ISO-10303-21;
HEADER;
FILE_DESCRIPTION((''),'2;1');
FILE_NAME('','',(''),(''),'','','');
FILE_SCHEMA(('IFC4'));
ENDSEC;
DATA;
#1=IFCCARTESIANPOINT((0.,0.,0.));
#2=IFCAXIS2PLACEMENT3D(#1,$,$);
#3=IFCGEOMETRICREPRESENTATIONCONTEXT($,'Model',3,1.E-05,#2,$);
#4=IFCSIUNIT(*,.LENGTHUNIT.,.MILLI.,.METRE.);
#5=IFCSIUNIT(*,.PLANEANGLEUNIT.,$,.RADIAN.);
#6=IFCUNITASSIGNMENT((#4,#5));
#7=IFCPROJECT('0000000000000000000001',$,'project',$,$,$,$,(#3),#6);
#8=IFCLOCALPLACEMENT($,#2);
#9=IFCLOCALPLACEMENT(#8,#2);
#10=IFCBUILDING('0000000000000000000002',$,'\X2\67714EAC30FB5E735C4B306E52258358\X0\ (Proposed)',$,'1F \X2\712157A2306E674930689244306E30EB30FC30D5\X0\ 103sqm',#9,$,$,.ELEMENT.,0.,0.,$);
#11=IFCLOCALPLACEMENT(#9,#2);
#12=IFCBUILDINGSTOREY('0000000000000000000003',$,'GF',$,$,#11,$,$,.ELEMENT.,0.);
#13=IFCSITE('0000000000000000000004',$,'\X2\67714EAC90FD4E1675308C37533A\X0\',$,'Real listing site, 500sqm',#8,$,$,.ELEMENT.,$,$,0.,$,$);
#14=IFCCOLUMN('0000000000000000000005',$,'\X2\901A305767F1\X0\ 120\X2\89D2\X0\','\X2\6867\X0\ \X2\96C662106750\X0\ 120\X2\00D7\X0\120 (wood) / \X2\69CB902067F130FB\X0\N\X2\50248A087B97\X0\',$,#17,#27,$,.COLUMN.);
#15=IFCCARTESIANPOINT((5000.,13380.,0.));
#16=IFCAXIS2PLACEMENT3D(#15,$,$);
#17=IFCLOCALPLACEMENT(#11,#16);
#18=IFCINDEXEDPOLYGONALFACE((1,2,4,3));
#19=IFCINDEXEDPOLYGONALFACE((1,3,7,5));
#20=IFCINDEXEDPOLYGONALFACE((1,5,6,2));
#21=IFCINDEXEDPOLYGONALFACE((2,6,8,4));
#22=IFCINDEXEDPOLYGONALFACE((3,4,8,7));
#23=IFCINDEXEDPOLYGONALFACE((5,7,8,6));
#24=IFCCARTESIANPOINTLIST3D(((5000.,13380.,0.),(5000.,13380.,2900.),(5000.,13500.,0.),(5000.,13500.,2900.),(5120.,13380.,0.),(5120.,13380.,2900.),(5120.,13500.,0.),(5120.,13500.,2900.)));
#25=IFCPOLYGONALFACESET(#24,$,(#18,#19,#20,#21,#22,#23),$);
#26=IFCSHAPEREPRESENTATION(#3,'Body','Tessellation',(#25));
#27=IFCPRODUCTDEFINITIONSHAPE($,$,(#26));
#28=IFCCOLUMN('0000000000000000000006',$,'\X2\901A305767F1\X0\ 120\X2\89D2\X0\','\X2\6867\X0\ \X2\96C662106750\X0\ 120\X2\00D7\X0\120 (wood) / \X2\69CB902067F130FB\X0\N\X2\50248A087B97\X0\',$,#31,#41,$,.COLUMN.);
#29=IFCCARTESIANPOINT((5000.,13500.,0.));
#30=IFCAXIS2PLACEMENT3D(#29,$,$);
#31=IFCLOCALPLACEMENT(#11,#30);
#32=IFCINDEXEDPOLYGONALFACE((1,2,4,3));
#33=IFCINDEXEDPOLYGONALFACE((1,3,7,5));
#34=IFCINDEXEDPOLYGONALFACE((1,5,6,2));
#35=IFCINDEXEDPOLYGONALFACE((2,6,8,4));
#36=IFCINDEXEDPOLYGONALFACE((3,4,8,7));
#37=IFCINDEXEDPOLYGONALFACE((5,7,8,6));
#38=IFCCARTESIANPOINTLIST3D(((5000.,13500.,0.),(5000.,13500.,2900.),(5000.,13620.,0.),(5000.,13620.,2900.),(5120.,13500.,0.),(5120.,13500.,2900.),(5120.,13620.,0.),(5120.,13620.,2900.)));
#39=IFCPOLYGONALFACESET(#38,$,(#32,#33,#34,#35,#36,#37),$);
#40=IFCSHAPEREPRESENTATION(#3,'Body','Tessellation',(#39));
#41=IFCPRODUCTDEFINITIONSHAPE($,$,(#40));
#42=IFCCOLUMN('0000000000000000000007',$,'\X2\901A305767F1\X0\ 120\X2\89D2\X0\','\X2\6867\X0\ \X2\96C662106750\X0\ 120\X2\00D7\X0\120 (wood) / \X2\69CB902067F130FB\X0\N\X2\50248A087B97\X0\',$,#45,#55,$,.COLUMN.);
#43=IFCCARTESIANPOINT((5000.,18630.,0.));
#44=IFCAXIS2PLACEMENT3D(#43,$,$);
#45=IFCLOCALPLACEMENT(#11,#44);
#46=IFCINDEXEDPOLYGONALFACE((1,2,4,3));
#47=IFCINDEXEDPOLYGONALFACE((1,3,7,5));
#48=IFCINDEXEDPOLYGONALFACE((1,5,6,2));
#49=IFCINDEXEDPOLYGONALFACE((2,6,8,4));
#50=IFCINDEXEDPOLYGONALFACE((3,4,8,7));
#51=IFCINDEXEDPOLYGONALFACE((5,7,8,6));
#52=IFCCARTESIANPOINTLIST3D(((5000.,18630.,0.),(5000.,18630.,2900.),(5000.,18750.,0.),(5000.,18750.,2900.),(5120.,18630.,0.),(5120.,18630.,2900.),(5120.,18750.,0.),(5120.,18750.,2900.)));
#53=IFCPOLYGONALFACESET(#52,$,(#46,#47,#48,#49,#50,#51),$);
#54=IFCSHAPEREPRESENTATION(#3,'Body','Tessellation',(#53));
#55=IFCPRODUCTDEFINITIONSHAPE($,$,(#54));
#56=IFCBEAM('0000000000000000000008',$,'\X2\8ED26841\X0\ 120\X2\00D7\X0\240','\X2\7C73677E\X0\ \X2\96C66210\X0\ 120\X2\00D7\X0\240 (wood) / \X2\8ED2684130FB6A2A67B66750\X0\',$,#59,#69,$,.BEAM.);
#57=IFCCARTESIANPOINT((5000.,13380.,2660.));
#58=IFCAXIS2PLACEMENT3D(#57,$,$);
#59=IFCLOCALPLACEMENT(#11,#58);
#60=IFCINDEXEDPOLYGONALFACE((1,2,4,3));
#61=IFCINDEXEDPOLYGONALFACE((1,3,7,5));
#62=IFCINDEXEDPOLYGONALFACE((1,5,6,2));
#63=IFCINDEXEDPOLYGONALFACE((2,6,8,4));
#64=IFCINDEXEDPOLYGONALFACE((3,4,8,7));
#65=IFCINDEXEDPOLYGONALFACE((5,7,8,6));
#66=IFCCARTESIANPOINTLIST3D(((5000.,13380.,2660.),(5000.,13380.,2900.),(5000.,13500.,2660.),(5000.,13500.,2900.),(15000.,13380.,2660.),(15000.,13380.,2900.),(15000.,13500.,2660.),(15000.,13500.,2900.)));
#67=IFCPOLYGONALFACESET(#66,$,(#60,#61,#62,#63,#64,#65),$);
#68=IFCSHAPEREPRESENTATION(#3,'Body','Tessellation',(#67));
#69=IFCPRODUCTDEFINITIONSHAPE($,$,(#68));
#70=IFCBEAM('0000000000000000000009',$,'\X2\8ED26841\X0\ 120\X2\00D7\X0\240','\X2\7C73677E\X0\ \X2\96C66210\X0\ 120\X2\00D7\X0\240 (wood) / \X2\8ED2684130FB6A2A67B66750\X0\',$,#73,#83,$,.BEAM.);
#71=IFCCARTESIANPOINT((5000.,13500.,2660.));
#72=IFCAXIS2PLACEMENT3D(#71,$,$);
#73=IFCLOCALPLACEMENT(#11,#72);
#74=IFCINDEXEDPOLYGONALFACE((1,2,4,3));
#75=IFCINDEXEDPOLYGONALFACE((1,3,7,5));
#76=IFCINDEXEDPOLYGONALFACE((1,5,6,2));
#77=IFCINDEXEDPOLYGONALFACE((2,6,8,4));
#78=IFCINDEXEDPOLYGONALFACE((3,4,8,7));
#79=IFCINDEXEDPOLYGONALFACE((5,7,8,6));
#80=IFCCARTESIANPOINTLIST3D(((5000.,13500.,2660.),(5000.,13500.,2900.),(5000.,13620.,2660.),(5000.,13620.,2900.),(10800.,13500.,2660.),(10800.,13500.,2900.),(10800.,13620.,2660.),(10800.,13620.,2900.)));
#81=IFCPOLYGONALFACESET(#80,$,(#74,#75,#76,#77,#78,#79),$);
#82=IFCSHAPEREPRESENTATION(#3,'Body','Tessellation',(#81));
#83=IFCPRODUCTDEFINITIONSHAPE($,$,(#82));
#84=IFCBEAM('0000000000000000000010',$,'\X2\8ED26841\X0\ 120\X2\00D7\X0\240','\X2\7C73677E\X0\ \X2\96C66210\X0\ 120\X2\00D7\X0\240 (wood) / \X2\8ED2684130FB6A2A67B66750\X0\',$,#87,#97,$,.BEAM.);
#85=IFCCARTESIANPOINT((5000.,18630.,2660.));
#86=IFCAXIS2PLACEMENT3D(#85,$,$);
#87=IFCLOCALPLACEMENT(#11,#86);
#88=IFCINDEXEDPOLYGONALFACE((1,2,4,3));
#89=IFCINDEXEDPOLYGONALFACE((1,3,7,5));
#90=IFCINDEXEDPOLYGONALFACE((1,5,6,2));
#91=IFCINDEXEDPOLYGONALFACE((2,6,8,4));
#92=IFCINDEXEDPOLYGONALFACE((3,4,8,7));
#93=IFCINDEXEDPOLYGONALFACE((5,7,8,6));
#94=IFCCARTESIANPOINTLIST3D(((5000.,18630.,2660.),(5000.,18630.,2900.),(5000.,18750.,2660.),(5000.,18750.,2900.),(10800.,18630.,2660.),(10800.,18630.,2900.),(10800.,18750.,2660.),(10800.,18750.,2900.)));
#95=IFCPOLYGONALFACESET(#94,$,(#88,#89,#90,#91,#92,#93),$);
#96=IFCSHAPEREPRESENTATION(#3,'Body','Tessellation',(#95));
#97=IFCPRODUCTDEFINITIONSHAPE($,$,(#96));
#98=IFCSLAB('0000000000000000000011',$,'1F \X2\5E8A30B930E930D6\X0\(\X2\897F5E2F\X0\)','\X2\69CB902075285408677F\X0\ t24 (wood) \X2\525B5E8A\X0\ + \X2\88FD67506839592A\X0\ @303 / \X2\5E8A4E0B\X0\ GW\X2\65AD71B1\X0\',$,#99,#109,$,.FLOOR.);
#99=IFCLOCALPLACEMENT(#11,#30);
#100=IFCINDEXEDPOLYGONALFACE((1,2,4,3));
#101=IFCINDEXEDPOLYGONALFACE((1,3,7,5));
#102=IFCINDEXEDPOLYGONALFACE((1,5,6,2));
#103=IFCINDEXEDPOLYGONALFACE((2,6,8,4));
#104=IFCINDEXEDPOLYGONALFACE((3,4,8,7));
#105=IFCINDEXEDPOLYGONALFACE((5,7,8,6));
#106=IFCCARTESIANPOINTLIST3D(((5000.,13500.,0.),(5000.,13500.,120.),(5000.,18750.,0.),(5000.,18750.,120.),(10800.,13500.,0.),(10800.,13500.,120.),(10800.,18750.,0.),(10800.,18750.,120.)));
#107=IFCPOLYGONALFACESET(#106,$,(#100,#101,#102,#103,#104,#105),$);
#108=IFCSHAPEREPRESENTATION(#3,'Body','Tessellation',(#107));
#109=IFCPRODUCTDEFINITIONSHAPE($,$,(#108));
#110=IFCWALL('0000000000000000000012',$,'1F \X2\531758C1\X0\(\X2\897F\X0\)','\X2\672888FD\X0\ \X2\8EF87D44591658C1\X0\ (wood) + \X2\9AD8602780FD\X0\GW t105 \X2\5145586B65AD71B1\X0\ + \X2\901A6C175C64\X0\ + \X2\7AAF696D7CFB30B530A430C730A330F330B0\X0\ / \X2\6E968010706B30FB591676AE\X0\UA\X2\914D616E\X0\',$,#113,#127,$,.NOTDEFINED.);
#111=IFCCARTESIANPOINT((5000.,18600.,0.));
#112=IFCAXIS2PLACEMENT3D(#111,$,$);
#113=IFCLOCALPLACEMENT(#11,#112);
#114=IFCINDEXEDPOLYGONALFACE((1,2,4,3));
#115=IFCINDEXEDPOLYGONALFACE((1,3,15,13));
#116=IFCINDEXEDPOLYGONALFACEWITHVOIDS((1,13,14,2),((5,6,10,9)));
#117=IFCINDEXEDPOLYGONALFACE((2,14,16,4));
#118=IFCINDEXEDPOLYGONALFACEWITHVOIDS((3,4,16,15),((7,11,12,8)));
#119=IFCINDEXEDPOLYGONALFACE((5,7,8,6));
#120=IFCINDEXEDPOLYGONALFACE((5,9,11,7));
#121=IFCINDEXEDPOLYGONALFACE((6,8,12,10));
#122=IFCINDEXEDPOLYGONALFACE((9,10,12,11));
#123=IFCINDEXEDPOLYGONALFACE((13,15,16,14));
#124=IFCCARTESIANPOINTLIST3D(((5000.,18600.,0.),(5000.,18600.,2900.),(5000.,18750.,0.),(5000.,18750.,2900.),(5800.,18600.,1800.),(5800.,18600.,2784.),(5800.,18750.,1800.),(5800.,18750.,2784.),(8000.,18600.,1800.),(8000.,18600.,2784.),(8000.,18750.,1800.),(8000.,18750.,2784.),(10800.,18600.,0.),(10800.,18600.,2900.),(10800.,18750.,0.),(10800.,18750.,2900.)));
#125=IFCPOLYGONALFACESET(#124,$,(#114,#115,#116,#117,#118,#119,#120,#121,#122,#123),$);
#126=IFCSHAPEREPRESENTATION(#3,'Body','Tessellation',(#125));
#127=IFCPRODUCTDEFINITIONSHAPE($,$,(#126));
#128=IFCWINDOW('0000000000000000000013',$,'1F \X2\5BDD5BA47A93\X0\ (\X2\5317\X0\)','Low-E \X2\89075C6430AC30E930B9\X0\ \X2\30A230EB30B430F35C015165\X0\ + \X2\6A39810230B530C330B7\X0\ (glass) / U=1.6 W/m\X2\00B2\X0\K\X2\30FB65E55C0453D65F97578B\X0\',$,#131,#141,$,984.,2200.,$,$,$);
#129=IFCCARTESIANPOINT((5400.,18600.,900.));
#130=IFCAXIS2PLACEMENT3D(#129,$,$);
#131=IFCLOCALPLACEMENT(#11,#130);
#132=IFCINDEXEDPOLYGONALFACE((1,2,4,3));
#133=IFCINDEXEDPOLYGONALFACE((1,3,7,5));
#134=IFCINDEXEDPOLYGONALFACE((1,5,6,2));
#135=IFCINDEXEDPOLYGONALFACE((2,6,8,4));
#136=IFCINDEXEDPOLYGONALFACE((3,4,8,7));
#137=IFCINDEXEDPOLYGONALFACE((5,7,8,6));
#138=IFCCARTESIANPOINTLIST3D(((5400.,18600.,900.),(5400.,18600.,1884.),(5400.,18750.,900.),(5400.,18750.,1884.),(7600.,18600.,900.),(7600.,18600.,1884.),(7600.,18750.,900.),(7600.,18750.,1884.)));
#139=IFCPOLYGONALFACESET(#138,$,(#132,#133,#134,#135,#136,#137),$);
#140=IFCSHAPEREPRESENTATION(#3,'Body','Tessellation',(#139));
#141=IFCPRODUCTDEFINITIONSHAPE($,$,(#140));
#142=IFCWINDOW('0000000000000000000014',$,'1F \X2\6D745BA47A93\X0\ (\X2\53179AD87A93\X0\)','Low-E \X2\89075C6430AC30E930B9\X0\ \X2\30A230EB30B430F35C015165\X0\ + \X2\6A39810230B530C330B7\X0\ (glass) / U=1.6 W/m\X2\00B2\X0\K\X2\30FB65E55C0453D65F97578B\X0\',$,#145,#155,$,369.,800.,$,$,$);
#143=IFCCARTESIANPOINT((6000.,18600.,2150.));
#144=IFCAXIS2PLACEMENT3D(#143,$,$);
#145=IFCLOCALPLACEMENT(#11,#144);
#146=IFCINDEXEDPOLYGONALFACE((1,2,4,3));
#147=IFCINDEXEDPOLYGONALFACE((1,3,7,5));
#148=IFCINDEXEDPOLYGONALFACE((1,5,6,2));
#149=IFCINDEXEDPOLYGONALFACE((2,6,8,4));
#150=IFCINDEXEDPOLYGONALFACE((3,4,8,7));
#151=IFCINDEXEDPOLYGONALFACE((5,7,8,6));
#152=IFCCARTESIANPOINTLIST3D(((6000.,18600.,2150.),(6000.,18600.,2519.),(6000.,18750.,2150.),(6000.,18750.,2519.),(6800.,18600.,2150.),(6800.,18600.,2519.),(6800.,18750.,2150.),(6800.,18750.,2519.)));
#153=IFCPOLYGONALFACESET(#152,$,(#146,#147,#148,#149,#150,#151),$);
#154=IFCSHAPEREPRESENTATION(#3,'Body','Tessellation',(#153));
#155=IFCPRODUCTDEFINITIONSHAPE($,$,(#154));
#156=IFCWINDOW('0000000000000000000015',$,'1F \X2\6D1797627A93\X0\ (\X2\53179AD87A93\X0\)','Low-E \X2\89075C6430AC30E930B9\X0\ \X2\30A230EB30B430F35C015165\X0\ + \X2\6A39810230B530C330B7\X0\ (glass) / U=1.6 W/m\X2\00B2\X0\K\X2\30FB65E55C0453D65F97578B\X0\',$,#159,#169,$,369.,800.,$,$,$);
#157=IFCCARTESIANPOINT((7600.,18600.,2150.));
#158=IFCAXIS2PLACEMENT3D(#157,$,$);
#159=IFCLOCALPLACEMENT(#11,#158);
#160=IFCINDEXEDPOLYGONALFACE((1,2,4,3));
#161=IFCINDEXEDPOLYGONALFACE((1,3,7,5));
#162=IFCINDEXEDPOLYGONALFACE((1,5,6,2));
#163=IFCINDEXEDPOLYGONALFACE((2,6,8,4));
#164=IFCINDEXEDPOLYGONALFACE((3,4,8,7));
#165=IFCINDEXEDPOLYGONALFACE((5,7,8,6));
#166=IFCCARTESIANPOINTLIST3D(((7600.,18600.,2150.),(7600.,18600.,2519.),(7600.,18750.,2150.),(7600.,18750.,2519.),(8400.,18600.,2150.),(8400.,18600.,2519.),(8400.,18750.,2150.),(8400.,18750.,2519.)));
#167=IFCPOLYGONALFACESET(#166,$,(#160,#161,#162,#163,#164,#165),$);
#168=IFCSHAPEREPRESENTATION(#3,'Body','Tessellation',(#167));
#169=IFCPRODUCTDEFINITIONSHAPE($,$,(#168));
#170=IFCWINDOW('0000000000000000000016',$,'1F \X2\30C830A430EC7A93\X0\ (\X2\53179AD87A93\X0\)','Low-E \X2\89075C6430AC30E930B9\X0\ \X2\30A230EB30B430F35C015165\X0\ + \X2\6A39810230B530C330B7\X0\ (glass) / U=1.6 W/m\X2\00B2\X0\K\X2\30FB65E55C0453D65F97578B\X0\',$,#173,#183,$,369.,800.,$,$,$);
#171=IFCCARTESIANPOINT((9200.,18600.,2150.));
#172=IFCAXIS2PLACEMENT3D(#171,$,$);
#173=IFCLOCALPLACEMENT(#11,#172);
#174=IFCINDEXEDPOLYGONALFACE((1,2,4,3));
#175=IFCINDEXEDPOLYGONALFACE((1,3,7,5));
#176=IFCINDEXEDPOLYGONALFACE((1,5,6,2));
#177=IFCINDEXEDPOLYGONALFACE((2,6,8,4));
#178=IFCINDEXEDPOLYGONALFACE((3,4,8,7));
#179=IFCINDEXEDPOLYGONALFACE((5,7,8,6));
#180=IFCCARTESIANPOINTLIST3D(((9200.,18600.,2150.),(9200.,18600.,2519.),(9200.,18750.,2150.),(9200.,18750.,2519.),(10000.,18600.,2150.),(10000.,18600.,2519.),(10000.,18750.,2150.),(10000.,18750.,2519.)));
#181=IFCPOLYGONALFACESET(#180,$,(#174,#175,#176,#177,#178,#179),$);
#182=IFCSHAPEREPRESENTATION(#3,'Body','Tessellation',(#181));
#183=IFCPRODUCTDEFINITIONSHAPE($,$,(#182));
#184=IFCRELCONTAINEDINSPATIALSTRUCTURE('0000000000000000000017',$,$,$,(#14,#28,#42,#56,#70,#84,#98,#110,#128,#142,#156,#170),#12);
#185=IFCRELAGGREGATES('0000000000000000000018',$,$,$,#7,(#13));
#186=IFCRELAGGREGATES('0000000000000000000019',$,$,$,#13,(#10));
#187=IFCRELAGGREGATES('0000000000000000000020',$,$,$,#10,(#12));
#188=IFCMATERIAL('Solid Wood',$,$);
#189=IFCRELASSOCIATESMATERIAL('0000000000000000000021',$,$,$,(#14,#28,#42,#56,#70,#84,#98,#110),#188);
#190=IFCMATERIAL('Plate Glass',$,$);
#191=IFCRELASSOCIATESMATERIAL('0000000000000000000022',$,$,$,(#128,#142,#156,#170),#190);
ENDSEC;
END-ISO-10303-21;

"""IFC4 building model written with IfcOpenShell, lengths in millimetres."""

from ifc_helpers import new_model, si_unit, frame, frame_2d, origin, place, context, project, spatial, rectangle, extrude, material, element, fill, save


model = new_model("IFC4")

# Units and contexts
model_context = context("Model", 3, precision=1e-05, world=origin())
ifc_project = project(units=[si_unit("LENGTHUNIT", "METRE", prefix="MILLI"), si_unit("PLANEANGLEUNIT", "RADIAN")], contexts=[model_context])

# Site, building, storey
site_placement = place(None, origin())
site = spatial("IfcSite", under=ifc_project, at=site_placement, Name="東京都世田谷区", ObjectType="Real listing site, 500sqm", CompositionType="ELEMENT", RefElevation=0.0)
building_placement = place(site_placement, origin())
building = spatial("IfcBuilding", under=site, at=building_placement, Name="東京・平屋の別荘 (Proposed)", ObjectType="1F 無垢の杉と鉄のルーフ 103sqm", CompositionType="ELEMENT", ElevationOfRefHeight=0.0, ElevationOfTerrain=0.0)
storey_placement = place(building_placement, origin())
storey = spatial("IfcBuildingStorey", under=building, at=storey_placement, Name="GF", CompositionType="ELEMENT", Elevation=0.0)

# Columns
ifc_material_1 = material(Name="Solid Wood")
column_1_placement = place(storey_placement, frame((5000.0, 13380.0, 0.0)))
element("IfcColumn", 1, at=column_1_placement, inside=storey, material=ifc_material_1, Name="通し柱 120角", Description="桧 集成材 120×120 (wood) / 構造柱・N値計算", PredefinedType="COLUMN", context=model_context, shape_type="SweptSolid", body=[
    extrude(rectangle(XDim=120.0, YDim=120.0, at=frame_2d((60.0, 60.0))), frame((5000.0, 13380.0, 0.0)), (0.0, 0.0, 1.0), 2900.0),
])
column_2_placement = place(storey_placement, frame((5000.0, 13500.0, 0.0)))
element("IfcColumn", 2, at=column_2_placement, inside=storey, material=ifc_material_1, Name="通し柱 120角", Description="桧 集成材 120×120 (wood) / 構造柱・N値計算", PredefinedType="COLUMN", context=model_context, shape_type="SweptSolid", body=[
    extrude(rectangle(XDim=120.0, YDim=120.0, at=frame_2d((60.0, 60.0))), frame((5000.0, 13500.0, 0.0)), (0.0, 0.0, 1.0), 2900.0),
])
column_3_placement = place(storey_placement, frame((5000.0, 18630.0, 0.0)))
element("IfcColumn", 3, at=column_3_placement, inside=storey, material=ifc_material_1, Name="通し柱 120角", Description="桧 集成材 120×120 (wood) / 構造柱・N値計算", PredefinedType="COLUMN", context=model_context, shape_type="SweptSolid", body=[
    extrude(rectangle(XDim=120.0, YDim=120.0, at=frame_2d((60.0, 60.0))), frame((5000.0, 18630.0, 0.0)), (0.0, 0.0, 1.0), 2900.0),
])

# Beams
beam_1_placement = place(storey_placement, frame((5000.0, 13380.0, 2660.0)))
element("IfcBeam", 4, at=beam_1_placement, inside=storey, material=ifc_material_1, Name="軒桁 120×240", Description="米松 集成 120×240 (wood) / 軒桁・横架材", PredefinedType="BEAM", context=model_context, shape_type="SweptSolid", body=[
    extrude(rectangle(XDim=10000.0, YDim=120.0, at=frame_2d((5000.0, 60.0))), frame((5000.0, 13380.0, 2660.0)), (0.0, 0.0, 1.0), 240.0),
])
beam_2_placement = place(storey_placement, frame((5000.0, 13500.0, 2660.0)))
element("IfcBeam", 5, at=beam_2_placement, inside=storey, material=ifc_material_1, Name="軒桁 120×240", Description="米松 集成 120×240 (wood) / 軒桁・横架材", PredefinedType="BEAM", context=model_context, shape_type="SweptSolid", body=[
    extrude(rectangle(XDim=5800.0, YDim=120.0, at=frame_2d((2900.0, 60.0))), frame((5000.0, 13500.0, 2660.0)), (0.0, 0.0, 1.0), 240.0),
])
beam_3_placement = place(storey_placement, frame((5000.0, 18630.0, 2660.0)))
element("IfcBeam", 6, at=beam_3_placement, inside=storey, material=ifc_material_1, Name="軒桁 120×240", Description="米松 集成 120×240 (wood) / 軒桁・横架材", PredefinedType="BEAM", context=model_context, shape_type="SweptSolid", body=[
    extrude(rectangle(XDim=5800.0, YDim=120.0, at=frame_2d((2900.0, 60.0))), frame((5000.0, 18630.0, 2660.0)), (0.0, 0.0, 1.0), 240.0),
])

# Slab
slab_placement = place(storey_placement, frame((5000.0, 13500.0, 0.0)))
element("IfcSlab", 7, at=slab_placement, inside=storey, material=ifc_material_1, Name="1F 床スラブ(西帯)", Description="構造用合板 t24 (wood) 剛床 + 製材根太 @303 / 床下 GW断熱", PredefinedType="FLOOR", context=model_context, shape_type="SweptSolid", body=[
    extrude(rectangle(XDim=5800.0, YDim=5250.0, at=frame_2d((2900.0, 2625.0))), frame((5000.0, 13500.0, 0.0)), (0.0, 0.0, 1.0), 120.0),
])

# Wall, openings, windows
wall_1_placement = place(storey_placement, frame((5000.0, 18600.0, 0.0)))
wall_1 = element("IfcWall", 8, at=wall_1_placement, inside=storey, material=ifc_material_1, Name="1F 北壁(西)", Description="木製 軸組外壁 (wood) + 高性能GW t105 充填断熱 + 通気層 + 窯業系サイディング / 準耐火・外皮UA配慮", PredefinedType="NOTDEFINED", context=model_context, shape_type="SweptSolid", body=[
    extrude(rectangle(XDim=5800.0, YDim=150.0, at=frame_2d((2900.0, 75.0))), frame((5000.0, 18600.0, 0.0)), (0.0, 0.0, 1.0), 2900.0),
])
opening_1_placement = place(storey_placement, frame((5400.0, 18600.0, 900.0)))
opening_1 = element("IfcOpeningElement", 9, at=opening_1_placement, cuts=wall_1, PredefinedType="NOTDEFINED", context=model_context, shape_type="SweptSolid", body=[
    extrude(rectangle(XDim=2200.0, YDim=150.0, at=frame_2d((1100.0, 75.0))), frame((5400.0, 18600.0, 900.0)), (0.0, 0.0, 1.0), 984.0),
])
opening_2_placement = place(storey_placement, frame((6000.0, 18600.0, 2150.0)))
opening_2 = element("IfcOpeningElement", 10, at=opening_2_placement, cuts=wall_1, PredefinedType="NOTDEFINED", context=model_context, shape_type="SweptSolid", body=[
    extrude(rectangle(XDim=800.0, YDim=150.0, at=frame_2d((400.0, 75.0))), frame((6000.0, 18600.0, 2150.0)), (0.0, 0.0, 1.0), 369.0),
])
opening_3_placement = place(storey_placement, frame((7600.0, 18600.0, 2150.0)))
opening_3 = element("IfcOpeningElement", 11, at=opening_3_placement, cuts=wall_1, PredefinedType="NOTDEFINED", context=model_context, shape_type="SweptSolid", body=[
    extrude(rectangle(XDim=800.0, YDim=150.0, at=frame_2d((400.0, 75.0))), frame((7600.0, 18600.0, 2150.0)), (0.0, 0.0, 1.0), 369.0),
])
opening_4_placement = place(storey_placement, frame((9200.0, 18600.0, 2150.0)))
opening_4 = element("IfcOpeningElement", 12, at=opening_4_placement, cuts=wall_1, PredefinedType="NOTDEFINED", context=model_context, shape_type="SweptSolid", body=[
    extrude(rectangle(XDim=800.0, YDim=150.0, at=frame_2d((400.0, 75.0))), frame((9200.0, 18600.0, 2150.0)), (0.0, 0.0, 1.0), 369.0),
])
ifc_material_2 = material(Name="Plate Glass")
window_1_placement = place(storey_placement, frame((5400.0, 18600.0, 900.0)))
window_1 = element("IfcWindow", 13, at=window_1_placement, inside=storey, material=ifc_material_2, Name="1F 寝室窓 (北)", Description="Low-E 複層ガラス アルゴン封入 + 樹脂サッシ (glass) / U=1.6 W/m²K・日射取得型", OverallHeight=984.0, OverallWidth=2200.0, context=model_context, shape_type="SweptSolid", body=[
    extrude(rectangle(XDim=2200.0, YDim=150.0, at=frame_2d((1100.0, 75.0))), frame((5400.0, 18600.0, 900.0)), (0.0, 0.0, 1.0), 984.0),
])
fill(opening_1, window_1)
window_2_placement = place(storey_placement, frame((6000.0, 18600.0, 2150.0)))
window_2 = element("IfcWindow", 14, at=window_2_placement, inside=storey, material=ifc_material_2, Name="1F 浴室窓 (北高窓)", Description="Low-E 複層ガラス アルゴン封入 + 樹脂サッシ (glass) / U=1.6 W/m²K・日射取得型", OverallHeight=369.0, OverallWidth=800.0, context=model_context, shape_type="SweptSolid", body=[
    extrude(rectangle(XDim=800.0, YDim=150.0, at=frame_2d((400.0, 75.0))), frame((6000.0, 18600.0, 2150.0)), (0.0, 0.0, 1.0), 369.0),
])
fill(opening_2, window_2)
window_3_placement = place(storey_placement, frame((7600.0, 18600.0, 2150.0)))
window_3 = element("IfcWindow", 15, at=window_3_placement, inside=storey, material=ifc_material_2, Name="1F 洗面窓 (北高窓)", Description="Low-E 複層ガラス アルゴン封入 + 樹脂サッシ (glass) / U=1.6 W/m²K・日射取得型", OverallHeight=369.0, OverallWidth=800.0, context=model_context, shape_type="SweptSolid", body=[
    extrude(rectangle(XDim=800.0, YDim=150.0, at=frame_2d((400.0, 75.0))), frame((7600.0, 18600.0, 2150.0)), (0.0, 0.0, 1.0), 369.0),
])
fill(opening_3, window_3)
window_4_placement = place(storey_placement, frame((9200.0, 18600.0, 2150.0)))
window_4 = element("IfcWindow", 16, at=window_4_placement, inside=storey, material=ifc_material_2, Name="1F トイレ窓 (北高窓)", Description="Low-E 複層ガラス アルゴン封入 + 樹脂サッシ (glass) / U=1.6 W/m²K・日射取得型", OverallHeight=369.0, OverallWidth=800.0, context=model_context, shape_type="SweptSolid", body=[
    extrude(rectangle(XDim=800.0, YDim=150.0, at=frame_2d((400.0, 75.0))), frame((9200.0, 18600.0, 2150.0)), (0.0, 0.0, 1.0), 369.0),
])
fill(opening_4, window_4)

save(model, "model.ifc")
